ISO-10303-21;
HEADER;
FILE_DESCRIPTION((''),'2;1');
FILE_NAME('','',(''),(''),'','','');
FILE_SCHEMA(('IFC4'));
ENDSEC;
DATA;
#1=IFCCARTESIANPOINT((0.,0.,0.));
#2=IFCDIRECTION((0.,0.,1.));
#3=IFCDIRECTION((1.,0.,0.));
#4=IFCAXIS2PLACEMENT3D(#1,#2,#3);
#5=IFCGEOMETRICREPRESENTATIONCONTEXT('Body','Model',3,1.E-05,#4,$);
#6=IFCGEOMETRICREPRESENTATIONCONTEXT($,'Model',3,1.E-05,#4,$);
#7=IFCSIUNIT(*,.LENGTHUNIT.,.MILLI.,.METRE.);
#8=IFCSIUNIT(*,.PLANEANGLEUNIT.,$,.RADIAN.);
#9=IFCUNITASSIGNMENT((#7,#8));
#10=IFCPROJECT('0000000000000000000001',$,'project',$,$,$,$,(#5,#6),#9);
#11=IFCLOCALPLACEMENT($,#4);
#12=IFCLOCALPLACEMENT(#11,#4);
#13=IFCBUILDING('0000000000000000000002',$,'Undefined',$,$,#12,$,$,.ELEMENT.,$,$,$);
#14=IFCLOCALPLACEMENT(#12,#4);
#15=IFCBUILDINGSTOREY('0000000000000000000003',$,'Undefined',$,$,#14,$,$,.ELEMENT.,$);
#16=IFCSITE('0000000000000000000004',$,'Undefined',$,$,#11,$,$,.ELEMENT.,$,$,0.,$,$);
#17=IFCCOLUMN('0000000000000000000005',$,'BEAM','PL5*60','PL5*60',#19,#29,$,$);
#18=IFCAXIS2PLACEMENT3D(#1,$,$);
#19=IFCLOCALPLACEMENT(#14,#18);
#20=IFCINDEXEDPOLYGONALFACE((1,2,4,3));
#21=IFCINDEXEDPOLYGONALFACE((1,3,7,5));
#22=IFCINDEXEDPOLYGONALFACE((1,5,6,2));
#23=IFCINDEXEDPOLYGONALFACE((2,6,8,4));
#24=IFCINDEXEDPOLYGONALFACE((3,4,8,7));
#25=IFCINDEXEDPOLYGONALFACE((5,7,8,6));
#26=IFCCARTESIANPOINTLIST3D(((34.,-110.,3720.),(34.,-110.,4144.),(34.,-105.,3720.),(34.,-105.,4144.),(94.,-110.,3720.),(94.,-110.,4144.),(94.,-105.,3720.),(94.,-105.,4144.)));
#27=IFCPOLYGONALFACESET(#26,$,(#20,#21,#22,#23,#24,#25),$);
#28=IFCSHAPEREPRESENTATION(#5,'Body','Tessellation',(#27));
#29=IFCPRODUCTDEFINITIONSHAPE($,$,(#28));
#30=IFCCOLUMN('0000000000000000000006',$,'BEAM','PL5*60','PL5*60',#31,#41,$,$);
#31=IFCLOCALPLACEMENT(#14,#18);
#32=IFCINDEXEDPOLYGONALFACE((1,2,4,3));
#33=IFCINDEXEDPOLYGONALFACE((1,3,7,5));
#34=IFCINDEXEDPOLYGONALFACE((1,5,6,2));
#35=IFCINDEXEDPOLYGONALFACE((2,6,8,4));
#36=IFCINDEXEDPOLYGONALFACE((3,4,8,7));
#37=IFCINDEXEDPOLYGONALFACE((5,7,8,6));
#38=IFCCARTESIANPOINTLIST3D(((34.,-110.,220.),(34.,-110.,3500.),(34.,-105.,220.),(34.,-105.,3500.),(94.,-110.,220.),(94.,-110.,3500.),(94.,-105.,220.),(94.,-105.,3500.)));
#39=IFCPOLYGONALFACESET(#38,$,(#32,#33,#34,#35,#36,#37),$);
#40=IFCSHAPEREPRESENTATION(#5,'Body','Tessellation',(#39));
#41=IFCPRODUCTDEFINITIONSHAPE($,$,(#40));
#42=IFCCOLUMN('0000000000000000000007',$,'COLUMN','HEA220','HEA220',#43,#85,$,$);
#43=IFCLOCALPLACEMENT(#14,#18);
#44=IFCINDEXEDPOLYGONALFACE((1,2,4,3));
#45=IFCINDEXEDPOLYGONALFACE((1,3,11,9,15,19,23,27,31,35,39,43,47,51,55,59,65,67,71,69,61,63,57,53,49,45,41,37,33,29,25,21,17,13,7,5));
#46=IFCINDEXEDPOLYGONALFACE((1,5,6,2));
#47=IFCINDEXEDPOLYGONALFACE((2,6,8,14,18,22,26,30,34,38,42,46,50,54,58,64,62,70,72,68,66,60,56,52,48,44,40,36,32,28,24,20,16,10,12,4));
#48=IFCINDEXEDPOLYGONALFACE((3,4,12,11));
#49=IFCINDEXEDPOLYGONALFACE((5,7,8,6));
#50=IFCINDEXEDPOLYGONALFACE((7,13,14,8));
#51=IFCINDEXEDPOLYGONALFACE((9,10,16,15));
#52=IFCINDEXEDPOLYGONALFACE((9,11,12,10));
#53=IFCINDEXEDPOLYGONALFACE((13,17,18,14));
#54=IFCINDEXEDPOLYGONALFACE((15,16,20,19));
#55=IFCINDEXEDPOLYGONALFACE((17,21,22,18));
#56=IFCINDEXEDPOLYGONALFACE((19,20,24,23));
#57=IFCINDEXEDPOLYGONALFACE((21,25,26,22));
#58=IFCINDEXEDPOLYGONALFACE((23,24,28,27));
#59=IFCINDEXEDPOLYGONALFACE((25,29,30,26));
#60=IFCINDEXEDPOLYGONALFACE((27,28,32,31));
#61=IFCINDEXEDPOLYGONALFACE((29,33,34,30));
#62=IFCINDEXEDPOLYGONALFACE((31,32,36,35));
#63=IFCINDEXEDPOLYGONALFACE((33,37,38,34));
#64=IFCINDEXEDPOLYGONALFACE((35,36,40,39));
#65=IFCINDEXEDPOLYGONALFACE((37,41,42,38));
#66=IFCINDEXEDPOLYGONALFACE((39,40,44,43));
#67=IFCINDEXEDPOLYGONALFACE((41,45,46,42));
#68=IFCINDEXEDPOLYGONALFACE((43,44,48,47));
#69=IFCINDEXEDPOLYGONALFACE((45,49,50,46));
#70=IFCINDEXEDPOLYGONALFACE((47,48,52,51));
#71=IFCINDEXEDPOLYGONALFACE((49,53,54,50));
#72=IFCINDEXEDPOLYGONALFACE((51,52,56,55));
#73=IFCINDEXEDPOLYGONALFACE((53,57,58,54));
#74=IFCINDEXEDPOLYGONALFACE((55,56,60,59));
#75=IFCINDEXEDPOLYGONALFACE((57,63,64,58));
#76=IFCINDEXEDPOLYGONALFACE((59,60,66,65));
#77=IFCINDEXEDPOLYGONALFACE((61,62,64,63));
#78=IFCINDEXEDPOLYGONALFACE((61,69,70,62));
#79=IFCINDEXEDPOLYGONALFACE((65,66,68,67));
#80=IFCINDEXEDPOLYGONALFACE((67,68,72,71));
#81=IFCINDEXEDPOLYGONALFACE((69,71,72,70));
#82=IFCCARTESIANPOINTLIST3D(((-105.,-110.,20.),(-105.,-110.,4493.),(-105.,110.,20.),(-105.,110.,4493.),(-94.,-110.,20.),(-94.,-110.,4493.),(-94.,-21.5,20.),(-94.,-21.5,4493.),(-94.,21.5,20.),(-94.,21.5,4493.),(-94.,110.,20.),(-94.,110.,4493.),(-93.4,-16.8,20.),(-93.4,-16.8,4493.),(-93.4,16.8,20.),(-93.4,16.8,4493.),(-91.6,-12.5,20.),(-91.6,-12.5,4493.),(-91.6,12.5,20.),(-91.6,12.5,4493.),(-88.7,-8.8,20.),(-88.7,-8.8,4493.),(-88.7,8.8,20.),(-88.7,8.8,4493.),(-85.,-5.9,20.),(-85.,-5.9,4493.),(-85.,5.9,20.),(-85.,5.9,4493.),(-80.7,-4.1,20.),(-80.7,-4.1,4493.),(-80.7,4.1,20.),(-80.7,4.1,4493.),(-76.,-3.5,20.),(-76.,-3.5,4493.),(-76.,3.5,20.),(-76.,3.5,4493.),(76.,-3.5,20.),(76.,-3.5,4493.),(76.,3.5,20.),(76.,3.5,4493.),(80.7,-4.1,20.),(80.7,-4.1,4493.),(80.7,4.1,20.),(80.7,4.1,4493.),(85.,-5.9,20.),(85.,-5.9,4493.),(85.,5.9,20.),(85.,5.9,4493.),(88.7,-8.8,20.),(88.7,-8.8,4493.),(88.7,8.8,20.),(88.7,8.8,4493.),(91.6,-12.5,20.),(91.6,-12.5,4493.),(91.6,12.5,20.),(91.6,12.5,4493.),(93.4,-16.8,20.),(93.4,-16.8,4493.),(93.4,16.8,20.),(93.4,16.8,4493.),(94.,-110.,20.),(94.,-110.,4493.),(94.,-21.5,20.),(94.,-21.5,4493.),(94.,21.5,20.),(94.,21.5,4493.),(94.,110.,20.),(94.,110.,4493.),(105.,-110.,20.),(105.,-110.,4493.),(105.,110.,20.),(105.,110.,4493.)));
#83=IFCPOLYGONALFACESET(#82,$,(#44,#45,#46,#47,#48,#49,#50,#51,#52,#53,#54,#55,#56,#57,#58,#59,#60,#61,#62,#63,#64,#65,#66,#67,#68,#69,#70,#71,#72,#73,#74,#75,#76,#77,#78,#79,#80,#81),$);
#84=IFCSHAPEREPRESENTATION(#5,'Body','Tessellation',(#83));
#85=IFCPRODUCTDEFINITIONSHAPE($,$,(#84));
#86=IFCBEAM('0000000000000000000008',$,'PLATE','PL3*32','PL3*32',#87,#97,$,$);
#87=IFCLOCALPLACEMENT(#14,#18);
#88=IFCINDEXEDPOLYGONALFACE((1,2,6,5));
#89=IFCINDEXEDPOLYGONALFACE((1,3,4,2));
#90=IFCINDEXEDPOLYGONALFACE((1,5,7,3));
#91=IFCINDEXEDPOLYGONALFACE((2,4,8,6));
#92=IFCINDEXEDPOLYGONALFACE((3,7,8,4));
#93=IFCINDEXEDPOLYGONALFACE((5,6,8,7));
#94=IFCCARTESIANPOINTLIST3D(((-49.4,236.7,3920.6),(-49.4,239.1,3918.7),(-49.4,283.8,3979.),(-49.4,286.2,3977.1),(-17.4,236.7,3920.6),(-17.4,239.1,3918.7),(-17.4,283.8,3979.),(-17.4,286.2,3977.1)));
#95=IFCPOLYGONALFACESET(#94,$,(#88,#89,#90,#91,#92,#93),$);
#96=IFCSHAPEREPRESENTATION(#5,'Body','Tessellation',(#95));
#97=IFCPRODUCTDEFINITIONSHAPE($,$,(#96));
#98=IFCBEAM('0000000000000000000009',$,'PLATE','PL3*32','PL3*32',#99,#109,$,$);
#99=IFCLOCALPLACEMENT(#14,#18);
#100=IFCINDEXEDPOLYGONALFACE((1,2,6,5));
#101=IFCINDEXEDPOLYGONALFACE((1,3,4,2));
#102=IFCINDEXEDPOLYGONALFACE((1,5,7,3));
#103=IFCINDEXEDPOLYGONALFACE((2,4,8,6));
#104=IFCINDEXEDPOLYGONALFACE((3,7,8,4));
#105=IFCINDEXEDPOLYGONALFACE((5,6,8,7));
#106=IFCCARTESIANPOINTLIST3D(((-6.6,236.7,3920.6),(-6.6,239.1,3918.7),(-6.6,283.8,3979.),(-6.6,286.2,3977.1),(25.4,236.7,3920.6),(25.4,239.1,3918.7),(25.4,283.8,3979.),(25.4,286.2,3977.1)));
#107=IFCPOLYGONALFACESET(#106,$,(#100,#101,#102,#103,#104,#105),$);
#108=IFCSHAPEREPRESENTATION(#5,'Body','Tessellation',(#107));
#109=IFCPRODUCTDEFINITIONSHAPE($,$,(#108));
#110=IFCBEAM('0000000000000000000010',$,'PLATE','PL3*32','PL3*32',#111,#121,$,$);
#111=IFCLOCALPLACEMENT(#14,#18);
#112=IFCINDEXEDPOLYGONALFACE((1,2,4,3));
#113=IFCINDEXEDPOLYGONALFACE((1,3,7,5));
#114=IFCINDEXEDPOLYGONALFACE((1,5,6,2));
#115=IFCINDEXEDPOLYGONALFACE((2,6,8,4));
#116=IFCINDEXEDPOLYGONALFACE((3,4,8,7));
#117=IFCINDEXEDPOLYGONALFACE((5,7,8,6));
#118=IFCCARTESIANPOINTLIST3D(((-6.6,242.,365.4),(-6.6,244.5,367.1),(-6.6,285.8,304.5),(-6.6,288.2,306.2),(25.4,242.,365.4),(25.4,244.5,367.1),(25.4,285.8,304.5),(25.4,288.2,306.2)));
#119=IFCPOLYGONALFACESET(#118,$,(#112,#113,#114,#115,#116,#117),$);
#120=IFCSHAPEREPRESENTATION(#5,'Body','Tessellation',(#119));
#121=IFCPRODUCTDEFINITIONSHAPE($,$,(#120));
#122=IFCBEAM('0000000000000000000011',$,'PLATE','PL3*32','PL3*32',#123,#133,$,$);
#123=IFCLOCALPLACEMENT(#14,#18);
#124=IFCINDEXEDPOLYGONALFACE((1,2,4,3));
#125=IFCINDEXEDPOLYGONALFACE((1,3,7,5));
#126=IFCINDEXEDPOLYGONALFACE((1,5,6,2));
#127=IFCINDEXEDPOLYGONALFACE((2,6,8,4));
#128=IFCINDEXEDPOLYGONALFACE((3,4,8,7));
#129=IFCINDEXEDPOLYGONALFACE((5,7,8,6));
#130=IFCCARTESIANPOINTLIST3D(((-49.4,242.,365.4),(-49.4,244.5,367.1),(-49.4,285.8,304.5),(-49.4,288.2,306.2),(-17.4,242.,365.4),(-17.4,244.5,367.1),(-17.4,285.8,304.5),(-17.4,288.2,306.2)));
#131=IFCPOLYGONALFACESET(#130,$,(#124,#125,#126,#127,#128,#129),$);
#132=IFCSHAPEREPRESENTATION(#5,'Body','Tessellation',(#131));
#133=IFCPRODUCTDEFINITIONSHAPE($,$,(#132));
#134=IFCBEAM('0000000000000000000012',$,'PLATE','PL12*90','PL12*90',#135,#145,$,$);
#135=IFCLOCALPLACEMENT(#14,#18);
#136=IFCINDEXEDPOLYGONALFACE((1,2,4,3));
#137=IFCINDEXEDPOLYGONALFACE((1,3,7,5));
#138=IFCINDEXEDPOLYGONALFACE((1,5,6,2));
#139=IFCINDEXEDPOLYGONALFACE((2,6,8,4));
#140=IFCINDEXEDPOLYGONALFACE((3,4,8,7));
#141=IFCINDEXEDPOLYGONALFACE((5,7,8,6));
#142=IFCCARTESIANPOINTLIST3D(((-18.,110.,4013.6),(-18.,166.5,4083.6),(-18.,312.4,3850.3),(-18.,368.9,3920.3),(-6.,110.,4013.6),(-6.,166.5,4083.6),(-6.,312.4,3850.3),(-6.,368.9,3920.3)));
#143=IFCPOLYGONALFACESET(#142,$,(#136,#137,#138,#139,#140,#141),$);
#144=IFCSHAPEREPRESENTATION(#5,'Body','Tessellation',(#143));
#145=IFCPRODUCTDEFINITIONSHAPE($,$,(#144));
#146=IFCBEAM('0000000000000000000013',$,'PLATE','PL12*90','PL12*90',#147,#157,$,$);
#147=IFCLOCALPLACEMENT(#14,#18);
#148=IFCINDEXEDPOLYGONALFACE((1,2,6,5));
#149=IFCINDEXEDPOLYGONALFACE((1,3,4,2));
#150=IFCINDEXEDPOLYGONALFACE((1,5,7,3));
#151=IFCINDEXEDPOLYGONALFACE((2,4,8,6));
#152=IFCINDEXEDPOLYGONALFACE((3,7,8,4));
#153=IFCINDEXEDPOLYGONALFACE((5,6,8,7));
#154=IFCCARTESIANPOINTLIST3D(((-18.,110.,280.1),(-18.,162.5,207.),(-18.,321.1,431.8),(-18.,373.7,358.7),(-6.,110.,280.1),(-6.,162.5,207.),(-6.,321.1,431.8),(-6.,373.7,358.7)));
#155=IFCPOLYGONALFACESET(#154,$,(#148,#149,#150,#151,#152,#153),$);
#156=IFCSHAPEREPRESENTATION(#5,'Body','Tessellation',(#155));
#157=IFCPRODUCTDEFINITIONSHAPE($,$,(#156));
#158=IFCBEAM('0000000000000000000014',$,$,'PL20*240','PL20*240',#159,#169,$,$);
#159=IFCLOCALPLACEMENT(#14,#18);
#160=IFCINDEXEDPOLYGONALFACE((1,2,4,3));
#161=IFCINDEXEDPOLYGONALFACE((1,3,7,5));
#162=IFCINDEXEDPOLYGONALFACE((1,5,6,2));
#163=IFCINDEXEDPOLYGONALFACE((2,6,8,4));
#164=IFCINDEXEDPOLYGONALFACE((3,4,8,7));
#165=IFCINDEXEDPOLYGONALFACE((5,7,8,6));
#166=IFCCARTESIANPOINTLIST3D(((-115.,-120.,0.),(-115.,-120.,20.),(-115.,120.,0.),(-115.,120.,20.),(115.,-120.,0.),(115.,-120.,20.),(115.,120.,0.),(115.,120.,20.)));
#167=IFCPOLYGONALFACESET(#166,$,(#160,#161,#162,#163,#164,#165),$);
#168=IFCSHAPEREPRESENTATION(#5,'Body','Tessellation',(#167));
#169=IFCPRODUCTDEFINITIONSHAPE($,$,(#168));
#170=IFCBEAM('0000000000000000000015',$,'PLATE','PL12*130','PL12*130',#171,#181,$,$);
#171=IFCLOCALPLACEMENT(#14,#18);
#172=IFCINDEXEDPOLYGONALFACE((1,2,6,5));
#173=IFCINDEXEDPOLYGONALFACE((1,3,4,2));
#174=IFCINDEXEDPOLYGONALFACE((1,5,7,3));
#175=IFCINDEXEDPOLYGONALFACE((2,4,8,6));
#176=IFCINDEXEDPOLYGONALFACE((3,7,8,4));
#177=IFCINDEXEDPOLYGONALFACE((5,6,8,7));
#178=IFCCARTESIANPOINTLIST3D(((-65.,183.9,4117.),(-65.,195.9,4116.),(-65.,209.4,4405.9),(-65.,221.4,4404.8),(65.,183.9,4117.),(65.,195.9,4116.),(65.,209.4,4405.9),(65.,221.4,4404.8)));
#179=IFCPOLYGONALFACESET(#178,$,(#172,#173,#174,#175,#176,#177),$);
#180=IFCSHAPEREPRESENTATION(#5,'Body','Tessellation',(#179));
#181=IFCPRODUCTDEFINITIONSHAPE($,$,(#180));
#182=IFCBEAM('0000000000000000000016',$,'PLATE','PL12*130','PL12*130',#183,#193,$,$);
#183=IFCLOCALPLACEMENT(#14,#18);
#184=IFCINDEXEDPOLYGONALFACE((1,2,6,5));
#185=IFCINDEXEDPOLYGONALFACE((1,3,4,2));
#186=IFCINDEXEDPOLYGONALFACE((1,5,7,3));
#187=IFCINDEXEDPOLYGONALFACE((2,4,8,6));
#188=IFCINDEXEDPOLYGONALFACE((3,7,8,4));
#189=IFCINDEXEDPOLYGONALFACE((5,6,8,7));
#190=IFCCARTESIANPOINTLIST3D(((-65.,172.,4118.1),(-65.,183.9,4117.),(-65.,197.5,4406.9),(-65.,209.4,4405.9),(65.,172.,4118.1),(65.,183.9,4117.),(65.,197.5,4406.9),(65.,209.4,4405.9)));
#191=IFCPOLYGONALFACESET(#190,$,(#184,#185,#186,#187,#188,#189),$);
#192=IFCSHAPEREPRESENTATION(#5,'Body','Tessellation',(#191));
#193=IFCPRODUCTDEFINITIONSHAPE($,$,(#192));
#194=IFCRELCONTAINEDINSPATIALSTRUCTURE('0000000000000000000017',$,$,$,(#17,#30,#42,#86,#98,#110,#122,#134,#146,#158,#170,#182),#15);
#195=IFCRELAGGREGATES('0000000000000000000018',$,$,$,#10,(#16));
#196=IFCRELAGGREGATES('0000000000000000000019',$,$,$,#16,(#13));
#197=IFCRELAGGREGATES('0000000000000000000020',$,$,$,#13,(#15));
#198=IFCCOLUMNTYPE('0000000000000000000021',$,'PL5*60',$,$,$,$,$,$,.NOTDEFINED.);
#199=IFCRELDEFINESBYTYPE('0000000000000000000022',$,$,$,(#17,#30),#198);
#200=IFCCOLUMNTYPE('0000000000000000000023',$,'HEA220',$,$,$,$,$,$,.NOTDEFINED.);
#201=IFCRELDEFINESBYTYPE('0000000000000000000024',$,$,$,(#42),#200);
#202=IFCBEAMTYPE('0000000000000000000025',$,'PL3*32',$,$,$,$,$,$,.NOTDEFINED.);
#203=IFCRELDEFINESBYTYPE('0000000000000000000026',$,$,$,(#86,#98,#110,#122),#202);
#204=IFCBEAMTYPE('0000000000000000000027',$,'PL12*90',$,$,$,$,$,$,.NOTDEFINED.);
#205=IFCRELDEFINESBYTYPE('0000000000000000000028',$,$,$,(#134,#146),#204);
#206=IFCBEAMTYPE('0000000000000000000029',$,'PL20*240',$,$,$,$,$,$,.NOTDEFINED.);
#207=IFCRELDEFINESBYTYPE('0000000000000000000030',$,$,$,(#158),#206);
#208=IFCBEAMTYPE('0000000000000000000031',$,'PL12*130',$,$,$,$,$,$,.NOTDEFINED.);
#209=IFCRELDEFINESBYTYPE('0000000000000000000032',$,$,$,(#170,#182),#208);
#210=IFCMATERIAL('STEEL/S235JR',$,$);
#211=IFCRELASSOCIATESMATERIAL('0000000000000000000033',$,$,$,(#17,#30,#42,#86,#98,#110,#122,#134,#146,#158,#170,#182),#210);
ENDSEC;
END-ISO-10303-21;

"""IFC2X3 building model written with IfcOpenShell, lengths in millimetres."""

from ifc_helpers import new_model, si_unit, frame, origin_with_axes, origin_2d_with_axis, place, context, project, spatial, rectangle, i_section, extrude, material, type_object, element, save


model = new_model("IFC2X3")

# Units and contexts
model_context_1 = context("Model", 3, precision=1e-05, world=origin_with_axes(), identifier="Body")
model_context_2 = context("Model", 3, precision=1e-05, world=origin_with_axes())
ifc_project = project(units=[si_unit("LENGTHUNIT", "METRE", prefix="MILLI"), si_unit("PLANEANGLEUNIT", "RADIAN")], contexts=[model_context_1, model_context_2])

# Site, building, storey
site_placement = place(None, origin_with_axes())
site = spatial("IfcSite", under=ifc_project, at=site_placement, Name="Undefined", CompositionType="ELEMENT", RefElevation=0.0)
building_placement = place(site_placement, origin_with_axes())
building = spatial("IfcBuilding", under=site, at=building_placement, Name="Undefined", CompositionType="ELEMENT")
storey_placement = place(building_placement, origin_with_axes())
storey = spatial("IfcBuildingStorey", under=building, at=storey_placement, Name="Undefined", CompositionType="ELEMENT")

# Columns
ifc_material = material(Name="STEEL/S235JR")
column_type_1 = type_object("IfcColumnType", Name="PL5*60", PredefinedType="NOTDEFINED")
column_1_placement = place(storey_placement, frame((64.0, -107.5, 3720.0), z_axis=(0.0, 0.0, 1.0), x_axis=(1.0, 0.0, 0.0)))
element("IfcColumn", 1, at=column_1_placement, inside=storey, type_object=column_type_1, material=ifc_material, Name="BEAM", Description="PL5*60", ObjectType="PL5*60", context=model_context_1, shape_type="SweptSolid", body=[
    extrude(rectangle(XDim=5.0, YDim=60.0, at=origin_2d_with_axis()), frame((0.0, 0.0, 424.0), z_axis=(0.0, 0.0, -1.0), x_axis=(0.0, 1.0, 0.0)), (0.0, 0.0, 1.0), 424.0),
])
column_2_placement = place(storey_placement, frame((64.0, -107.5, 220.0), z_axis=(0.0, 0.0, 1.0), x_axis=(1.0, 0.0, 0.0)))
element("IfcColumn", 2, at=column_2_placement, inside=storey, type_object=column_type_1, material=ifc_material, Name="BEAM", Description="PL5*60", ObjectType="PL5*60", context=model_context_1, shape_type="SweptSolid", body=[
    extrude(rectangle(XDim=5.0, YDim=60.0, at=origin_2d_with_axis()), frame((0.0, 0.0, 3280.0), z_axis=(0.0, 0.0, -1.0), x_axis=(0.0, 1.0, 0.0)), (0.0, 0.0, 1.0), 3280.0),
])
column_type_2 = type_object("IfcColumnType", Name="HEA220", PredefinedType="NOTDEFINED")
column_3_placement = place(storey_placement, origin_with_axes())
element("IfcColumn", 3, at=column_3_placement, inside=storey, type_object=column_type_2, material=ifc_material, Name="COLUMN", Description="HEA220", ObjectType="HEA220", context=model_context_1, shape_type="SweptSolid", body=[
    extrude(i_section(OverallWidth=220.0, OverallDepth=210.0, WebThickness=7.0, FlangeThickness=11.0, FilletRadius=18.0, at=origin_2d_with_axis()), frame((0.0, 0.0, 4493.0), z_axis=(0.0, 0.0, -1.0), x_axis=(0.0, 1.0, 0.0)), (0.0, 0.0, 1.0), 4473.0),
])

# Beams
beam_type_1 = type_object("IfcBeamType", Name="PL3*32", PredefinedType="NOTDEFINED")
for number, where, z_axis, x_axis, name in (
    (4, (-33.4, 285.0, 3978.0), (1.0, 0.0, 0.0), (0.0, -0.627936, -0.778265), "PLATE"),
    (5, (9.4, 285.0, 3978.0), (-1.0, 0.0, 0.0), (0.0, -0.627936, -0.778265), "PLATE"),
):
    element("IfcBeam", number, at=place(storey_placement, frame(where, z_axis=z_axis, x_axis=x_axis)), inside=storey, type_object=beam_type_1, material=ifc_material, Name=name, Description="PL3*32", ObjectType="PL3*32", context=model_context_1, shape_type="SweptSolid", body=[
        extrude(rectangle(XDim=3.0, YDim=32.0, at=origin_2d_with_axis()), frame((75.0, 0.0, 0.0), z_axis=(-1.0, 0.0, 0.0), x_axis=(0.0, -1.0, 0.0)), (0.0, 0.0, 1.0), 75.0),
    ])
for number, where, z_axis, x_axis, name in (
    (6, (9.4, 243.2, 366.3), (-1.0, 0.0, 0.0), (0.0, 0.583515, -0.812102), "PLATE"),
    (7, (-33.4, 243.2, 366.3), (1.0, 0.0, 0.0), (0.0, 0.583515, -0.812102), "PLATE"),
):
    element("IfcBeam", number, at=place(storey_placement, frame(where, z_axis=z_axis, x_axis=x_axis)), inside=storey, type_object=beam_type_1, material=ifc_material, Name=name, Description="PL3*32", ObjectType="PL3*32", context=model_context_1, shape_type="SweptSolid", body=[
        extrude(rectangle(XDim=3.0, YDim=32.0, at=origin_2d_with_axis()), frame((75.0, 0.0, 0.0), z_axis=(-1.0, 0.0, 0.0), x_axis=(0.0, -1.0, 0.0)), (0.0, 0.0, 1.0), 75.0),
    ])
beam_type_2 = type_object("IfcBeamType", Name="PL12*90", PredefinedType="NOTDEFINED")
beam_1_placement = place(storey_placement, frame((-12.0, 138.3, 4048.6), z_axis=(0.0, 0.627892, 0.7783), x_axis=(0.0, 0.7783, -0.627892)))
element("IfcBeam", 8, at=beam_1_placement, inside=storey, type_object=beam_type_2, material=ifc_material, Name="PLATE", Description="PL12*90", ObjectType="PL12*90", context=model_context_1, shape_type="SweptSolid", body=[
    extrude(rectangle(XDim=12.0, YDim=90.0, at=origin_2d_with_axis()), frame((260.0, 0.0, 0.0), z_axis=(-1.0, 0.0, 0.0), x_axis=(0.0, -1.0, 0.0)), (0.0, 0.0, 1.0), 260.0),
])
beam_2_placement = place(storey_placement, frame((-12.0, 136.3, 243.5), z_axis=(0.0, 0.583515, -0.812102), x_axis=(0.0, 0.812102, 0.583515)))
element("IfcBeam", 9, at=beam_2_placement, inside=storey, type_object=beam_type_2, material=ifc_material, Name="PLATE", Description="PL12*90", ObjectType="PL12*90", context=model_context_1, shape_type="SweptSolid", body=[
    extrude(rectangle(XDim=12.0, YDim=90.0, at=origin_2d_with_axis()), frame((260.0, 0.0, 0.0), z_axis=(-1.0, 0.0, 0.0), x_axis=(0.0, -1.0, 0.0)), (0.0, 0.0, 1.0), 260.0),
])
beam_type_3 = type_object("IfcBeamType", Name="PL20*240", PredefinedType="NOTDEFINED")
beam_3_placement = place(storey_placement, frame((-115.0, 0.0, 10.0), z_axis=(0.0, 1.0, 0.0), x_axis=(1.0, 0.0, 0.0)))
element("IfcBeam", 10, at=beam_3_placement, inside=storey, type_object=beam_type_3, material=ifc_material, Description="PL20*240", ObjectType="PL20*240", context=model_context_1, shape_type="SweptSolid", body=[
    extrude(rectangle(XDim=20.0, YDim=240.0, at=origin_2d_with_axis()), frame((230.0, 0.0, 0.0), z_axis=(-1.0, 0.0, 0.0), x_axis=(0.0, -1.0, 0.0)), (0.0, 0.0, 1.0), 230.0),
])
beam_type_4 = type_object("IfcBeamType", Name="PL12*130", PredefinedType="NOTDEFINED")
beam_4_placement = place(storey_placement, frame((0.0, 189.9, 4116.5), z_axis=(-1.0, 0.0, 0.0), x_axis=(0.0, 0.08801, 0.99612)))
element("IfcBeam", 11, at=beam_4_placement, inside=storey, type_object=beam_type_4, material=ifc_material, Name="PLATE", Description="PL12*130", ObjectType="PL12*130", context=model_context_1, shape_type="SweptSolid", body=[
    extrude(rectangle(XDim=12.0, YDim=130.0, at=origin_2d_with_axis()), frame((290.0, 0.0, 0.0), z_axis=(-1.0, 0.0, 0.0), x_axis=(0.0, -1.0, 0.0)), (0.0, 0.0, 1.0), 290.0),
])
beam_5_placement = place(storey_placement, frame((0.0, 177.9, 4117.5), z_axis=(-1.0, 0.0, 0.0), x_axis=(0.0, 0.08801, 0.99612)))
element("IfcBeam", 12, at=beam_5_placement, inside=storey, type_object=beam_type_4, material=ifc_material, Name="PLATE", Description="PL12*130", ObjectType="PL12*130", context=model_context_1, shape_type="SweptSolid", body=[
    extrude(rectangle(XDim=12.0, YDim=130.0, at=origin_2d_with_axis()), frame((290.0, 0.0, 0.0), z_axis=(-1.0, 0.0, 0.0), x_axis=(0.0, -1.0, 0.0)), (0.0, 0.0, 1.0), 290.0),
])

save(model, "model.ifc")
